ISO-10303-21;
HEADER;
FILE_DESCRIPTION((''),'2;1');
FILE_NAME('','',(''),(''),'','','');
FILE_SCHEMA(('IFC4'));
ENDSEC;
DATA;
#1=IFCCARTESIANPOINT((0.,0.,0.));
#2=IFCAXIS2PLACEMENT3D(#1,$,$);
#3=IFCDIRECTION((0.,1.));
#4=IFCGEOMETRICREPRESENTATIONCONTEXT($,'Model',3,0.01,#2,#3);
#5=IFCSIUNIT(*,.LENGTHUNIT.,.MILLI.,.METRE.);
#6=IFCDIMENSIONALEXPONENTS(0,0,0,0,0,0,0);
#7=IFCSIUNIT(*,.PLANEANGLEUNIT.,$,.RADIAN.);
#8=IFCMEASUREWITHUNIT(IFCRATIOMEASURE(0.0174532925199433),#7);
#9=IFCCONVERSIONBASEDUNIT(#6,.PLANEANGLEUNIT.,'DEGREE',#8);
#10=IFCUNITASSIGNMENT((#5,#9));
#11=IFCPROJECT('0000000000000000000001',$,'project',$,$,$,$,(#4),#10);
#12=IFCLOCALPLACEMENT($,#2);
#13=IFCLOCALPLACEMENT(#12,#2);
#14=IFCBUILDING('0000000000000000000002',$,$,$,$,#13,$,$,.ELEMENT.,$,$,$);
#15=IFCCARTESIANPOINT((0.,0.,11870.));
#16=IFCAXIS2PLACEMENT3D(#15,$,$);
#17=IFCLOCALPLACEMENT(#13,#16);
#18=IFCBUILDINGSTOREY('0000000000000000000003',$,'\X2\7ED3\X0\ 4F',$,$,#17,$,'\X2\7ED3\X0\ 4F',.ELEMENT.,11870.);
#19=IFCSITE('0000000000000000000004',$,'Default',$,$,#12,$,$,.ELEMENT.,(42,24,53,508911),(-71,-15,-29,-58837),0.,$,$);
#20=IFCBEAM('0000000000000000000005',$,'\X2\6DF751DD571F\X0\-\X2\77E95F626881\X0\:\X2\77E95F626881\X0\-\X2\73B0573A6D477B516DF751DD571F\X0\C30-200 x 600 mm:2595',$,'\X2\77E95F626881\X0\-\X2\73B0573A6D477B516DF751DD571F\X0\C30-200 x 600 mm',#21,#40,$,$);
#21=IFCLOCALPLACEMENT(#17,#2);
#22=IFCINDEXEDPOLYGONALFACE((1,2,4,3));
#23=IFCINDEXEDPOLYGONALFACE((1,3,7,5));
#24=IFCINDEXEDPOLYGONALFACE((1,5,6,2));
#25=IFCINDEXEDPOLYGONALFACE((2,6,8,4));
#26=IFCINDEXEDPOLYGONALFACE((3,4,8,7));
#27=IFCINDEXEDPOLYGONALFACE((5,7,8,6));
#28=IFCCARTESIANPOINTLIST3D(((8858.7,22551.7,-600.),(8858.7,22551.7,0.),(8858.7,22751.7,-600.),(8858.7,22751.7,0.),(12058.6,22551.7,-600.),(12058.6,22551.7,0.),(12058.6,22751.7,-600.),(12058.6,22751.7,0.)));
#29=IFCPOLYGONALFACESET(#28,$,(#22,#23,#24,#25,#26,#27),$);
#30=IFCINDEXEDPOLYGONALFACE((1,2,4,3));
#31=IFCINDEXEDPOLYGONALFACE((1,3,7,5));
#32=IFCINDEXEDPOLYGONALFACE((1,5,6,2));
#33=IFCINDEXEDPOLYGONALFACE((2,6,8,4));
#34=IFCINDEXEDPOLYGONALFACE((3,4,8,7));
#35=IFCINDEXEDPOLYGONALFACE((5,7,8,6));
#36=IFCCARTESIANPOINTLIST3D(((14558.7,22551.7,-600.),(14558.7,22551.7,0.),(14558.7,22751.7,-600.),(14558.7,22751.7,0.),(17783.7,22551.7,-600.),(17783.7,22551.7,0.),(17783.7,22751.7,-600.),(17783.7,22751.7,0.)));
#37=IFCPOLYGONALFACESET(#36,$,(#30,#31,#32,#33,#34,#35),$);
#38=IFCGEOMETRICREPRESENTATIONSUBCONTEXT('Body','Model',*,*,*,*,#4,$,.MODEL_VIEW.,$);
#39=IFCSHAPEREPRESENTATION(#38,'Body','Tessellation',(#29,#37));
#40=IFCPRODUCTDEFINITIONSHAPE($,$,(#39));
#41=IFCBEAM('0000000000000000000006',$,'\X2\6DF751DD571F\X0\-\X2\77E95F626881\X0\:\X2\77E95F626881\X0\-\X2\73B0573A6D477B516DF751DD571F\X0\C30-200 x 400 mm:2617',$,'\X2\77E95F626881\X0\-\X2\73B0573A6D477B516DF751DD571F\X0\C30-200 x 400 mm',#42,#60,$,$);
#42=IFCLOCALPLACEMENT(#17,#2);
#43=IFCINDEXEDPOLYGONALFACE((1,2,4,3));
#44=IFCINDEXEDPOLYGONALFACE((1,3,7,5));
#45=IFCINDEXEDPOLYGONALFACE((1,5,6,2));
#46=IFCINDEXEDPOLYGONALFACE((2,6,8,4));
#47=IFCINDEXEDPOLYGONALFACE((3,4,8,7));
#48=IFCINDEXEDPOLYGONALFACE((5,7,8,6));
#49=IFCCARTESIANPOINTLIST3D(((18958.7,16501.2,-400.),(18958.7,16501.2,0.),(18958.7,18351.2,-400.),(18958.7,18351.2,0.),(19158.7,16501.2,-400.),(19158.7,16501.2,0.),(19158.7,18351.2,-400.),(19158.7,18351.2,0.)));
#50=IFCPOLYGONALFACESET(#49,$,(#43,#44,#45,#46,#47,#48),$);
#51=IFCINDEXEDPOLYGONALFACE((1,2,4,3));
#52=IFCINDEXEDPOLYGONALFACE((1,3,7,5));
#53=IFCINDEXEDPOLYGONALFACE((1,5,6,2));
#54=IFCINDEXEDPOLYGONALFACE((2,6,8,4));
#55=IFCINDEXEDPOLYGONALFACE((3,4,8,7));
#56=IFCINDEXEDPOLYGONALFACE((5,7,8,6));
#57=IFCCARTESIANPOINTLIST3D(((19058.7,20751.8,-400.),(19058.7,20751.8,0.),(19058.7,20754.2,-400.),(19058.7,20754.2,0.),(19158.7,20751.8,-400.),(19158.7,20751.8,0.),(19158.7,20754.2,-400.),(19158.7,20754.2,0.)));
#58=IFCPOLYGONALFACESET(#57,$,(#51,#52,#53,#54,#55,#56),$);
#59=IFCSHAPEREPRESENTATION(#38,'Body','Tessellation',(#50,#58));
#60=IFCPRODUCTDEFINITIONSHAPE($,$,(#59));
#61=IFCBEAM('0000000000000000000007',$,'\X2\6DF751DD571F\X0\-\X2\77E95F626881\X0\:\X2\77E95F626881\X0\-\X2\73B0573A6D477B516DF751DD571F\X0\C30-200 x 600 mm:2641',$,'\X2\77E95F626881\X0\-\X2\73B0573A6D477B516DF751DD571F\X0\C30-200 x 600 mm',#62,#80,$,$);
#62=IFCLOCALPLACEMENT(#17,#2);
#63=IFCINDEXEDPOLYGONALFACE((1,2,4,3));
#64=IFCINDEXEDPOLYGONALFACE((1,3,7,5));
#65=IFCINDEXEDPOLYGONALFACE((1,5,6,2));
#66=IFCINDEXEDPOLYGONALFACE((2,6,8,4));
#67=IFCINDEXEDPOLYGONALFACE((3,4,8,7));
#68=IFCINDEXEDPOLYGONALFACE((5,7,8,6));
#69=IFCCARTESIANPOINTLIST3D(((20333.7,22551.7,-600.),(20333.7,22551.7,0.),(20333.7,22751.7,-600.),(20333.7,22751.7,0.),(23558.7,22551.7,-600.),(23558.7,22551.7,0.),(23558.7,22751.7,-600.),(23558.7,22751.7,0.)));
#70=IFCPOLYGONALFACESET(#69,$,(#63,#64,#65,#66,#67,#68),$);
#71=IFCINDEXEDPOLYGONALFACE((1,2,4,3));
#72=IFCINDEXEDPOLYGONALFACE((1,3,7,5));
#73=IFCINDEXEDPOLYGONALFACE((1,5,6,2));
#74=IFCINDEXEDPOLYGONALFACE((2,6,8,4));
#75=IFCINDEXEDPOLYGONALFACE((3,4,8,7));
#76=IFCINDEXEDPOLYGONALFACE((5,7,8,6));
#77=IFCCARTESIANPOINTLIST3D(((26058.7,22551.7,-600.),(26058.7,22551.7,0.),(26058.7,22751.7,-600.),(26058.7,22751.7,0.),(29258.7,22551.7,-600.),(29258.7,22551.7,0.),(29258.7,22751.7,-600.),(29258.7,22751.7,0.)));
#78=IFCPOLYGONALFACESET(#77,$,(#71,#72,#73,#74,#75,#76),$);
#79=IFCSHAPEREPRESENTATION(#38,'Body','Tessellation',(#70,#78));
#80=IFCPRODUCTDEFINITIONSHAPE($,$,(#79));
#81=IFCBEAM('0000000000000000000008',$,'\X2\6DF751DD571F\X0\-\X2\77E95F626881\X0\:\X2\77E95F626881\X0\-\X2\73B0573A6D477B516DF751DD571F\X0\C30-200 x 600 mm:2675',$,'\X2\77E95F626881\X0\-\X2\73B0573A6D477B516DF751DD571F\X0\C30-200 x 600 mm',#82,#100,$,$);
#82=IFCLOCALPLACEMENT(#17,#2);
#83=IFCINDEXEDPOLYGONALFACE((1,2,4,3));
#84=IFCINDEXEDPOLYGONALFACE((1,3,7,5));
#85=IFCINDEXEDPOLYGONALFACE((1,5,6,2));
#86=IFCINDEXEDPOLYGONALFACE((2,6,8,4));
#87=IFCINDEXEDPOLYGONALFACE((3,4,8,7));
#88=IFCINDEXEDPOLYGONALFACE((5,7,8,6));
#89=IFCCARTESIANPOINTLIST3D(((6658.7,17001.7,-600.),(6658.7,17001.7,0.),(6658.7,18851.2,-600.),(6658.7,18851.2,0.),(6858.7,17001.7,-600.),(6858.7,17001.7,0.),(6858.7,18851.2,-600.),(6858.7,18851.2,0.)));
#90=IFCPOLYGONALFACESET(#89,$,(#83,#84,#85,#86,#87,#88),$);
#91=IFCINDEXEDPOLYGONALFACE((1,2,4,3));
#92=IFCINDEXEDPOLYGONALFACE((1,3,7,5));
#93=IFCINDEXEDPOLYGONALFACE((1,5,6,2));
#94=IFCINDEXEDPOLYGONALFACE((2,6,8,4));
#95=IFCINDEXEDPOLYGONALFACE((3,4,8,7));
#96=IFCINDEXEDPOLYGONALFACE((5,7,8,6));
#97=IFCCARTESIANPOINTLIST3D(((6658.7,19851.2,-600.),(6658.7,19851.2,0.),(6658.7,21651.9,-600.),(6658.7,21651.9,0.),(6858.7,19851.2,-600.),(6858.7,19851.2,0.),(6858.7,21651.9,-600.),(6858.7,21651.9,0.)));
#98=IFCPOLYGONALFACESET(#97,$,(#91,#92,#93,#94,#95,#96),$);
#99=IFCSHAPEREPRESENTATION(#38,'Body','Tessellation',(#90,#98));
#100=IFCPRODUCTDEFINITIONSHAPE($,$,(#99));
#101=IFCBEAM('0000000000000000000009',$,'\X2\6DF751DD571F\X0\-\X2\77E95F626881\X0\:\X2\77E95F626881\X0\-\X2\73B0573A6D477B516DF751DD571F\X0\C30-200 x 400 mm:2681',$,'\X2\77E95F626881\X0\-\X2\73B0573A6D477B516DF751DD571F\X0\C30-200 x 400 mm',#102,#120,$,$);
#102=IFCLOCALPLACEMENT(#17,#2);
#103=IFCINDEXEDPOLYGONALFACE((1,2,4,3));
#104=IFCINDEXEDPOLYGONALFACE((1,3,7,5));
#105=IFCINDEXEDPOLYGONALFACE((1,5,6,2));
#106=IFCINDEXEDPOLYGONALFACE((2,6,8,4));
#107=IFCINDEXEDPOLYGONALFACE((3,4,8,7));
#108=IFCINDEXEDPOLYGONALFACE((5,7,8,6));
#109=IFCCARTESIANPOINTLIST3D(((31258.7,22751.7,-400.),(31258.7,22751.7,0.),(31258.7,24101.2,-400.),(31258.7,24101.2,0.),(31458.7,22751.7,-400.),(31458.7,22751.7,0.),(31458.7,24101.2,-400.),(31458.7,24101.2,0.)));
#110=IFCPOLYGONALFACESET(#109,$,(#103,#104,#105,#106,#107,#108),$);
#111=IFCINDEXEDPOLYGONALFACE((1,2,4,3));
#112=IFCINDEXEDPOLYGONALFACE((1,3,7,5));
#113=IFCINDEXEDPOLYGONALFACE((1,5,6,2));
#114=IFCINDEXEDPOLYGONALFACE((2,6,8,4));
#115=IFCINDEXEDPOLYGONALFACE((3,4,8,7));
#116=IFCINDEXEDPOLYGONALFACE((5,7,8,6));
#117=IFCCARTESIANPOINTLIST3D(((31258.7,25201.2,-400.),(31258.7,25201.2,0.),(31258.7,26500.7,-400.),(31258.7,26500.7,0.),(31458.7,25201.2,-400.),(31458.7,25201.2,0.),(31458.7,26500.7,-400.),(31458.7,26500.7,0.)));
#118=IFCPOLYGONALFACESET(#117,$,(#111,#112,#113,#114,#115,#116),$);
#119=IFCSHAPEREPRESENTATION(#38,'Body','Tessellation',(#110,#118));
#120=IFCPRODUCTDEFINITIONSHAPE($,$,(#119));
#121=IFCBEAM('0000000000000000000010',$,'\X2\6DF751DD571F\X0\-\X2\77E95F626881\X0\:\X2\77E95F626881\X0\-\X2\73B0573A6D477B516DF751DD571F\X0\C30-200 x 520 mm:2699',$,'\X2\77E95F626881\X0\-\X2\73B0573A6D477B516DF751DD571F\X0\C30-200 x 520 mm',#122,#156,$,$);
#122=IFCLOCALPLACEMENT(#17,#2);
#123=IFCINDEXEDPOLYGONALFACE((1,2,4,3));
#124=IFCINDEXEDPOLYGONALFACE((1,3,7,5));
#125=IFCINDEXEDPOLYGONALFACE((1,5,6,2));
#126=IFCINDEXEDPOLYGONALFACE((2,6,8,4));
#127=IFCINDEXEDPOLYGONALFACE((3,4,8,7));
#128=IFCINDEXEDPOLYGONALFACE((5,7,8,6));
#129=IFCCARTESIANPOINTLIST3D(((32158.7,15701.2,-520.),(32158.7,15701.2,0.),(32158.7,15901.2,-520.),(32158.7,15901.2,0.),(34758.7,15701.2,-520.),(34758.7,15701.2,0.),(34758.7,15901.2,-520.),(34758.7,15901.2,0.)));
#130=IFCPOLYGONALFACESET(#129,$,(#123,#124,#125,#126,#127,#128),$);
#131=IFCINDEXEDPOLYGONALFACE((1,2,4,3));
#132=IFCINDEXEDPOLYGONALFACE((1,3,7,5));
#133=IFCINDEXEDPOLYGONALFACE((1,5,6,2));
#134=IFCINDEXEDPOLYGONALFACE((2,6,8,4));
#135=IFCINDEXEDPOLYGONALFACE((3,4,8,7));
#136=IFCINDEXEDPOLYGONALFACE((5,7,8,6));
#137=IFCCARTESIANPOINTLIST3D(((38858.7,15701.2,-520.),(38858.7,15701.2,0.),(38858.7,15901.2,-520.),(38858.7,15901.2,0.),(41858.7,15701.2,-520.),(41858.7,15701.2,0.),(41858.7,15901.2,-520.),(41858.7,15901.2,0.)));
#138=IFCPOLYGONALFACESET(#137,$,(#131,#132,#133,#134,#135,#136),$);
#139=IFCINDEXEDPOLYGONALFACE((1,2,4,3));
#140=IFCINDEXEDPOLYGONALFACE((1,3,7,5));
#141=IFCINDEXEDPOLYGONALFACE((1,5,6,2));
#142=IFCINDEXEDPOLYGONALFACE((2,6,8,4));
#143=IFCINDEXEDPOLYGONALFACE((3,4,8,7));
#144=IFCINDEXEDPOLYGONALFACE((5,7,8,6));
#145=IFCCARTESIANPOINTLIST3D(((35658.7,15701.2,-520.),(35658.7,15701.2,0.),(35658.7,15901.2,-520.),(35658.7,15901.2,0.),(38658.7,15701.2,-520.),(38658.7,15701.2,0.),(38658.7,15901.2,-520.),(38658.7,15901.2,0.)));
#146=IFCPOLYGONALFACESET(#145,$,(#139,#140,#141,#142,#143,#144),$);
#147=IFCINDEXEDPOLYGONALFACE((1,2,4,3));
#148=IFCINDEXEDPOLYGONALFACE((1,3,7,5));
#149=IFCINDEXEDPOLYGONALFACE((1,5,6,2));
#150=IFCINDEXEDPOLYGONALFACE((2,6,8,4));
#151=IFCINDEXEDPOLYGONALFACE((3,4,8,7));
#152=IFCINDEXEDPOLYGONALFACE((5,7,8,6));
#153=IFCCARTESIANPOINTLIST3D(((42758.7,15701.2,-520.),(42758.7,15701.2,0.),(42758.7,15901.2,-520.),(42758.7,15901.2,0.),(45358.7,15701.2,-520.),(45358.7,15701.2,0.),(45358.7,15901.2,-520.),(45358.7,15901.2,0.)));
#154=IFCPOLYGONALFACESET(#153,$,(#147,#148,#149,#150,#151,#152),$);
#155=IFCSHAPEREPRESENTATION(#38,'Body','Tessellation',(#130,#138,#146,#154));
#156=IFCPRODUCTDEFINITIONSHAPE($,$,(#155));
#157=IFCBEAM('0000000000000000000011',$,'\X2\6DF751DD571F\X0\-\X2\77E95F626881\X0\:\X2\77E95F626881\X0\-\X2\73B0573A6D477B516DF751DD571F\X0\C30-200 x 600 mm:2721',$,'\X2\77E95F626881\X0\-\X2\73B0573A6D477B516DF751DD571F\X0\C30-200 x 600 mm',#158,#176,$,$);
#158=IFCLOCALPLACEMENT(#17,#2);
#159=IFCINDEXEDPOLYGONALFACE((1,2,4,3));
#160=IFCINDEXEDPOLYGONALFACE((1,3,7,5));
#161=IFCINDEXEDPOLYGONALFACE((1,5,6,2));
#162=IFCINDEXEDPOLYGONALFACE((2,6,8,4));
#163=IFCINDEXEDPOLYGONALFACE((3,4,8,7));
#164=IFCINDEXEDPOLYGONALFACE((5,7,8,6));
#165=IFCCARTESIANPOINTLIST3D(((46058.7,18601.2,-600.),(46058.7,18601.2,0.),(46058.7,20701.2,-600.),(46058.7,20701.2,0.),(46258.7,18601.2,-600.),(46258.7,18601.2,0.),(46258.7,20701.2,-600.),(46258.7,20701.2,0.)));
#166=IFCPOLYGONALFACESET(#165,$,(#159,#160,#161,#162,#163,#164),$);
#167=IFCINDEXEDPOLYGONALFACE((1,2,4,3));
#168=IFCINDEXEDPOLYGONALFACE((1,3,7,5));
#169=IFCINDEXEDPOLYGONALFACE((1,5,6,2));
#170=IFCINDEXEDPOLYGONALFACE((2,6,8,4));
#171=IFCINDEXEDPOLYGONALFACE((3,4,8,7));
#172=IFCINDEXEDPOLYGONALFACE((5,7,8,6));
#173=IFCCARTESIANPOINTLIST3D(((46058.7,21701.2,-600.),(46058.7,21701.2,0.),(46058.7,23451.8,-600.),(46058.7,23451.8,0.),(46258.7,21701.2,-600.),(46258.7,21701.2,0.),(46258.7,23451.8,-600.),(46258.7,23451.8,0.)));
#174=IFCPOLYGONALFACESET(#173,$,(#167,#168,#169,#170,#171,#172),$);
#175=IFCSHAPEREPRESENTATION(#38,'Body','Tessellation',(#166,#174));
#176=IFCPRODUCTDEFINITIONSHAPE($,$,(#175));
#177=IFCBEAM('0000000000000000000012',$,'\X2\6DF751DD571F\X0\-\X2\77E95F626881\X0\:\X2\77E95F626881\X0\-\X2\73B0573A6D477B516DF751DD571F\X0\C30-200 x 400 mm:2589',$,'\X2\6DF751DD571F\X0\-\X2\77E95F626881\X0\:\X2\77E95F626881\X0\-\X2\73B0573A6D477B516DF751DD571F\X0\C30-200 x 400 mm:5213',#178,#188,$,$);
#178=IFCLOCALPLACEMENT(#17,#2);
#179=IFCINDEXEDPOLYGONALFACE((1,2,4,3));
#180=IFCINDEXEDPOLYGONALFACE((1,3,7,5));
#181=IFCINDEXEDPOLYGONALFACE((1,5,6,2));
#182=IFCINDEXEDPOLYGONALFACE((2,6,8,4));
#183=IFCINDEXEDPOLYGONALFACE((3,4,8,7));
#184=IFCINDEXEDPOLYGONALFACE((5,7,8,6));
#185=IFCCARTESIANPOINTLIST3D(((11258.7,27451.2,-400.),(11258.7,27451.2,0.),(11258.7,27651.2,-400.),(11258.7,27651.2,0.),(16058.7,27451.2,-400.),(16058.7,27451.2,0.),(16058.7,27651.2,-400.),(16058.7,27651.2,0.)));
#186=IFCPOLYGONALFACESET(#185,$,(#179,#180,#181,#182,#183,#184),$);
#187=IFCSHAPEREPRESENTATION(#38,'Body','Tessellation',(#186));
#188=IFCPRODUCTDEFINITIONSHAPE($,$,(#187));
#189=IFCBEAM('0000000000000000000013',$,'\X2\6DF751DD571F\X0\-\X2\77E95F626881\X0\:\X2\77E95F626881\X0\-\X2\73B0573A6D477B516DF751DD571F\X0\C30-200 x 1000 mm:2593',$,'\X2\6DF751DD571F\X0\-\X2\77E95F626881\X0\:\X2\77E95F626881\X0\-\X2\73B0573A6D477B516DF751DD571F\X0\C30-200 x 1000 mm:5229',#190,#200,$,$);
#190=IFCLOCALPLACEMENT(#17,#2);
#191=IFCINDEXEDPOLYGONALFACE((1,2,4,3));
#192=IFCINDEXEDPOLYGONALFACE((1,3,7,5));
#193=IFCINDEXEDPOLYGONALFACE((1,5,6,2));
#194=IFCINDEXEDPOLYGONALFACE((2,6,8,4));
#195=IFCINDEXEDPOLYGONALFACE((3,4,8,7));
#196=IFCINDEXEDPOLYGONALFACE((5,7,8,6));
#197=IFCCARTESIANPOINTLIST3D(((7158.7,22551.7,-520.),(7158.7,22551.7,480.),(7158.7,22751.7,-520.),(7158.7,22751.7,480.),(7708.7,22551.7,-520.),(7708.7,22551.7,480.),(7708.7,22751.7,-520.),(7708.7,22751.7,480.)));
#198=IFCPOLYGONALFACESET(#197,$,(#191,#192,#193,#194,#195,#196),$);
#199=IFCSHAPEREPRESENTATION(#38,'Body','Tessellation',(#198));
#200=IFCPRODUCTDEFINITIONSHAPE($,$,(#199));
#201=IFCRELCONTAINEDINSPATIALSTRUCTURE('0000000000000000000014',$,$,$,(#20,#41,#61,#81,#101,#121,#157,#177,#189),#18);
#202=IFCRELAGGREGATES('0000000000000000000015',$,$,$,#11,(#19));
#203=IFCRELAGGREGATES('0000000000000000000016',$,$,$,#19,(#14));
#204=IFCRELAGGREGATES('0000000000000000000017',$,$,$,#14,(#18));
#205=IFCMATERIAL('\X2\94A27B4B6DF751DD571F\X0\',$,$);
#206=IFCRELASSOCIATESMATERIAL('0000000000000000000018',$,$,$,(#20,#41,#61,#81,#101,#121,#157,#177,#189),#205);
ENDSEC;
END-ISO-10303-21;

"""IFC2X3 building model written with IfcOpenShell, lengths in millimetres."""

from ifc_helpers import new_model, entity, si_unit, converted_unit, direction, frame, frame_2d, origin, origin_2d_with_axis, place, context, subcontext, project, spatial, rectangle, extrude, source, transform, mapped, material, element, save


model = new_model("IFC2X3")

# Units and contexts
model_context = context("Model", 3, precision=0.01, world=origin(), true_north=direction((0.0, 1.0)))
body_context = subcontext(model_context, "Body", "Model", "MODEL_VIEW")
ifc_project = project(units=[si_unit("LENGTHUNIT", "METRE", prefix="MILLI"), converted_unit("PLANEANGLEUNIT", "DEGREE", entity("IfcRatioMeasure", 0.0174532925199433), si_unit("PLANEANGLEUNIT", "RADIAN"), dimensions=[0, 0, 0, 0, 0, 0, 0])], contexts=[model_context])

# Site, building, storey
site_placement = place(None, origin())
site = spatial("IfcSite", under=ifc_project, at=site_placement, Name="Default", CompositionType="ELEMENT", RefLatitude=(42, 24, 53, 508911), RefLongitude=(-71, -15, -29, -58837), RefElevation=0.0)
building_placement = place(site_placement, origin())
building = spatial("IfcBuilding", under=site, at=building_placement, CompositionType="ELEMENT")
storey_placement = place(building_placement, frame((0.0, 0.0, 11870.0)))
storey = spatial("IfcBuildingStorey", under=building, at=storey_placement, Name="结 4F", LongName="结 4F", CompositionType="ELEMENT", Elevation=11870.0)

# Beams
ifc_material = material(Name="钢筋混凝土")
shared_shape_1 = source(origin(), body_context, "Body", "SweptSolid", [
    extrude(rectangle(XDim=3200.0, YDim=200.0, at=origin_2d_with_axis()), frame((10458.7, 22651.7, 11270.0), z_axis=(0.0, 0.0, 1.0), x_axis=(-1.0, 0.0, 0.0)), (0.0, 0.0, 1.0), 600.0),
    extrude(rectangle(XDim=3225.0, YDim=200.0, at=origin_2d_with_axis()), frame((16171.2, 22651.7, 11270.0), z_axis=(0.0, 0.0, 1.0), x_axis=(-1.0, 0.0, 0.0)), (0.0, 0.0, 1.0), 600.0),
])
beam_1_placement = place(storey_placement, frame((0.0, 0.0, -11870.0)))
element("IfcBeam", 1, at=beam_1_placement, inside=storey, material=ifc_material, Name="混凝土-矩形梁:矩形梁-现场浇筑混凝土C30-200 x 600 mm:2595", ObjectType="矩形梁-现场浇筑混凝土C30-200 x 600 mm", context=body_context, shape_type="MappedRepresentation", body=[
    mapped(shared_shape_1, transform((0.0, 0.0, 0.0), scale=1.0)),
])
shared_shape_2 = source(origin(), body_context, "Body", "SweptSolid", [
    extrude(rectangle(XDim=1850.0, YDim=200.0, at=frame_2d((0.0, 0.0), x_axis=(1.0, 0.0))), frame((19058.7, 17426.2, 11470.0), z_axis=(0.0, 0.0, 1.0), x_axis=(0.0, -1.0, 0.0)), (0.0, 0.0, 1.0), 400.0),
    extrude(rectangle(XDim=100.0, YDim=2.4, at=origin_2d_with_axis()), frame((19108.7, 20753.0, 11470.0), z_axis=(0.0, 0.0, 1.0), x_axis=(-1.0, 0.0, 0.0)), (0.0, 0.0, 1.0), 400.0),
])
beam_2_placement = place(storey_placement, frame((0.0, 0.0, -11870.0)))
element("IfcBeam", 2, at=beam_2_placement, inside=storey, material=ifc_material, Name="混凝土-矩形梁:矩形梁-现场浇筑混凝土C30-200 x 400 mm:2617", ObjectType="矩形梁-现场浇筑混凝土C30-200 x 400 mm", context=body_context, shape_type="MappedRepresentation", body=[
    mapped(shared_shape_2, transform((0.0, 0.0, 0.0), scale=1.0)),
])
shared_shape_3 = source(origin(), body_context, "Body", "SweptSolid", [
    extrude(rectangle(XDim=3225.0, YDim=200.0, at=origin_2d_with_axis()), frame((21946.2, 22651.7, 11270.0)), (0.0, 0.0, 1.0), 600.0),
    extrude(rectangle(XDim=3200.0, YDim=200.0, at=frame_2d((0.0, 0.0), x_axis=(1.0, 0.0))), frame((27658.7, 22651.7, 11270.0)), (0.0, 0.0, 1.0), 600.0),
])
beam_3_placement = place(storey_placement, frame((0.0, 0.0, -11870.0)))
element("IfcBeam", 3, at=beam_3_placement, inside=storey, material=ifc_material, Name="混凝土-矩形梁:矩形梁-现场浇筑混凝土C30-200 x 600 mm:2641", ObjectType="矩形梁-现场浇筑混凝土C30-200 x 600 mm", context=body_context, shape_type="MappedRepresentation", body=[
    mapped(shared_shape_3, transform((0.0, 0.0, 0.0), scale=1.0)),
])
shared_shape_4 = source(origin(), body_context, "Body", "SweptSolid", [
    extrude(rectangle(XDim=1849.5, YDim=200.0, at=frame_2d((0.0, 0.0), x_axis=(1.0, 0.0))), frame((6758.7, 17926.5, 11270.0), z_axis=(0.0, 0.0, 1.0), x_axis=(0.0, 1.0, 0.0)), (0.0, 0.0, 1.0), 600.0),
    extrude(rectangle(XDim=1800.7, YDim=200.0, at=frame_2d((0.0, 0.0), x_axis=(1.0, 0.0))), frame((6758.7, 20751.6, 11270.0), z_axis=(0.0, 0.0, 1.0), x_axis=(0.0, -1.0, 0.0)), (0.0, 0.0, 1.0), 600.0),
])
beam_4_placement = place(storey_placement, frame((0.0, 0.0, -11870.0)))
element("IfcBeam", 4, at=beam_4_placement, inside=storey, material=ifc_material, Name="混凝土-矩形梁:矩形梁-现场浇筑混凝土C30-200 x 600 mm:2675", ObjectType="矩形梁-现场浇筑混凝土C30-200 x 600 mm", context=body_context, shape_type="MappedRepresentation", body=[
    mapped(shared_shape_4, transform((0.0, 0.0, 0.0), scale=1.0)),
])
shared_shape_5 = source(origin(), body_context, "Body", "SweptSolid", [
    extrude(rectangle(XDim=1349.5, YDim=200.0, at=frame_2d((0.0, 0.0), x_axis=(1.0, 0.0))), frame((31358.7, 23426.5, 11470.0), z_axis=(0.0, 0.0, 1.0), x_axis=(0.0, 1.0, 0.0)), (0.0, 0.0, 1.0), 400.0),
    extrude(rectangle(XDim=1299.5, YDim=200.0, at=frame_2d((0.0, 0.0), x_axis=(1.0, 0.0))), frame((31358.7, 25851.0, 11470.0), z_axis=(0.0, 0.0, 1.0), x_axis=(0.0, -1.0, 0.0)), (0.0, 0.0, 1.0), 400.0),
])
beam_5_placement = place(storey_placement, frame((0.0, 0.0, -11870.0)))
element("IfcBeam", 5, at=beam_5_placement, inside=storey, material=ifc_material, Name="混凝土-矩形梁:矩形梁-现场浇筑混凝土C30-200 x 400 mm:2681", ObjectType="矩形梁-现场浇筑混凝土C30-200 x 400 mm", context=body_context, shape_type="MappedRepresentation", body=[
    mapped(shared_shape_5, transform((0.0, 0.0, 0.0), scale=1.0)),
])
shared_shape_6 = source(origin(), body_context, "Body", "SweptSolid", [
    extrude(rectangle(XDim=2600.0, YDim=200.0, at=frame_2d((0.0, 0.0), x_axis=(1.0, 0.0))), frame((33458.7, 15801.2, 11350.0), z_axis=(0.0, 0.0, 1.0), x_axis=(-1.0, 0.0, 0.0)), (0.0, 0.0, 1.0), 520.0),
    extrude(rectangle(XDim=3000.0, YDim=200.0, at=origin_2d_with_axis()), frame((40358.7, 15801.2, 11350.0)), (0.0, 0.0, 1.0), 520.0),
    extrude(rectangle(XDim=3000.0, YDim=200.0, at=frame_2d((0.0, 0.0), x_axis=(1.0, 0.0))), frame((37158.7, 15801.2, 11350.0), z_axis=(0.0, 0.0, 1.0), x_axis=(-1.0, 0.0, 0.0)), (0.0, 0.0, 1.0), 520.0),
    extrude(rectangle(XDim=2600.0, YDim=200.0, at=frame_2d((0.0, 0.0), x_axis=(1.0, 0.0))), frame((44058.7, 15801.2, 11350.0)), (0.0, 0.0, 1.0), 520.0),
])
beam_6_placement = place(storey_placement, frame((0.0, 0.0, -11870.0)))
element("IfcBeam", 6, at=beam_6_placement, inside=storey, material=ifc_material, Name="混凝土-矩形梁:矩形梁-现场浇筑混凝土C30-200 x 520 mm:2699", ObjectType="矩形梁-现场浇筑混凝土C30-200 x 520 mm", context=body_context, shape_type="MappedRepresentation", body=[
    mapped(shared_shape_6, transform((0.0, 0.0, 0.0), scale=1.0)),
])
shared_shape_7 = source(origin(), body_context, "Body", "SweptSolid", [
    extrude(rectangle(XDim=2100.0, YDim=200.0, at=frame_2d((0.0, 0.0), x_axis=(1.0, 0.0))), frame((46158.7, 19651.2, 11270.0), z_axis=(0.0, 0.0, 1.0), x_axis=(0.0, 1.0, 0.0)), (0.0, 0.0, 1.0), 600.0),
    extrude(rectangle(XDim=1750.6, YDim=200.0, at=frame_2d((0.0, 0.0), x_axis=(1.0, 0.0))), frame((46158.7, 22576.5, 11270.0), z_axis=(0.0, 0.0, 1.0), x_axis=(0.0, 1.0, 0.0)), (0.0, 0.0, 1.0), 600.0),
])
beam_7_placement = place(storey_placement, frame((0.0, 0.0, -11870.0)))
element("IfcBeam", 7, at=beam_7_placement, inside=storey, material=ifc_material, Name="混凝土-矩形梁:矩形梁-现场浇筑混凝土C30-200 x 600 mm:2721", ObjectType="矩形梁-现场浇筑混凝土C30-200 x 600 mm", context=body_context, shape_type="MappedRepresentation", body=[
    mapped(shared_shape_7, transform((0.0, 0.0, 0.0), scale=1.0)),
])
beam_8_placement = place(storey_placement, frame((11158.7, 27551.2, 0.0)))
element("IfcBeam", 8, at=beam_8_placement, inside=storey, material=ifc_material, Name="混凝土-矩形梁:矩形梁-现场浇筑混凝土C30-200 x 400 mm:2589", ObjectType="混凝土-矩形梁:矩形梁-现场浇筑混凝土C30-200 x 400 mm:5213", context=body_context, shape_type="SweptSolid", body=[
    extrude(rectangle(XDim=400.0, YDim=200.0, at=frame_2d((0.0, 0.0), x_axis=(1.0, 0.0))), frame((100.0, 0.0, -200.0), z_axis=(1.0, 0.0, 0.0), x_axis=(0.0, 0.0, -1.0)), (0.0, 0.0, 1.0), 4800.0),
])
beam_9_placement = place(storey_placement, frame((6758.7, 22651.7, 480.0)))
element("IfcBeam", 9, at=beam_9_placement, inside=storey, material=ifc_material, Name="混凝土-矩形梁:矩形梁-现场浇筑混凝土C30-200 x 1000 mm:2593", ObjectType="混凝土-矩形梁:矩形梁-现场浇筑混凝土C30-200 x 1000 mm:5229", context=body_context, shape_type="SweptSolid", body=[
    extrude(rectangle(XDim=1000.0, YDim=200.0, at=frame_2d((0.0, 0.0), x_axis=(1.0, 0.0))), frame((400.0, 0.0, -500.0), z_axis=(1.0, 0.0, 0.0), x_axis=(0.0, 0.0, -1.0)), (0.0, 0.0, 1.0), 550.0),
])

save(model, "model.ifc")
